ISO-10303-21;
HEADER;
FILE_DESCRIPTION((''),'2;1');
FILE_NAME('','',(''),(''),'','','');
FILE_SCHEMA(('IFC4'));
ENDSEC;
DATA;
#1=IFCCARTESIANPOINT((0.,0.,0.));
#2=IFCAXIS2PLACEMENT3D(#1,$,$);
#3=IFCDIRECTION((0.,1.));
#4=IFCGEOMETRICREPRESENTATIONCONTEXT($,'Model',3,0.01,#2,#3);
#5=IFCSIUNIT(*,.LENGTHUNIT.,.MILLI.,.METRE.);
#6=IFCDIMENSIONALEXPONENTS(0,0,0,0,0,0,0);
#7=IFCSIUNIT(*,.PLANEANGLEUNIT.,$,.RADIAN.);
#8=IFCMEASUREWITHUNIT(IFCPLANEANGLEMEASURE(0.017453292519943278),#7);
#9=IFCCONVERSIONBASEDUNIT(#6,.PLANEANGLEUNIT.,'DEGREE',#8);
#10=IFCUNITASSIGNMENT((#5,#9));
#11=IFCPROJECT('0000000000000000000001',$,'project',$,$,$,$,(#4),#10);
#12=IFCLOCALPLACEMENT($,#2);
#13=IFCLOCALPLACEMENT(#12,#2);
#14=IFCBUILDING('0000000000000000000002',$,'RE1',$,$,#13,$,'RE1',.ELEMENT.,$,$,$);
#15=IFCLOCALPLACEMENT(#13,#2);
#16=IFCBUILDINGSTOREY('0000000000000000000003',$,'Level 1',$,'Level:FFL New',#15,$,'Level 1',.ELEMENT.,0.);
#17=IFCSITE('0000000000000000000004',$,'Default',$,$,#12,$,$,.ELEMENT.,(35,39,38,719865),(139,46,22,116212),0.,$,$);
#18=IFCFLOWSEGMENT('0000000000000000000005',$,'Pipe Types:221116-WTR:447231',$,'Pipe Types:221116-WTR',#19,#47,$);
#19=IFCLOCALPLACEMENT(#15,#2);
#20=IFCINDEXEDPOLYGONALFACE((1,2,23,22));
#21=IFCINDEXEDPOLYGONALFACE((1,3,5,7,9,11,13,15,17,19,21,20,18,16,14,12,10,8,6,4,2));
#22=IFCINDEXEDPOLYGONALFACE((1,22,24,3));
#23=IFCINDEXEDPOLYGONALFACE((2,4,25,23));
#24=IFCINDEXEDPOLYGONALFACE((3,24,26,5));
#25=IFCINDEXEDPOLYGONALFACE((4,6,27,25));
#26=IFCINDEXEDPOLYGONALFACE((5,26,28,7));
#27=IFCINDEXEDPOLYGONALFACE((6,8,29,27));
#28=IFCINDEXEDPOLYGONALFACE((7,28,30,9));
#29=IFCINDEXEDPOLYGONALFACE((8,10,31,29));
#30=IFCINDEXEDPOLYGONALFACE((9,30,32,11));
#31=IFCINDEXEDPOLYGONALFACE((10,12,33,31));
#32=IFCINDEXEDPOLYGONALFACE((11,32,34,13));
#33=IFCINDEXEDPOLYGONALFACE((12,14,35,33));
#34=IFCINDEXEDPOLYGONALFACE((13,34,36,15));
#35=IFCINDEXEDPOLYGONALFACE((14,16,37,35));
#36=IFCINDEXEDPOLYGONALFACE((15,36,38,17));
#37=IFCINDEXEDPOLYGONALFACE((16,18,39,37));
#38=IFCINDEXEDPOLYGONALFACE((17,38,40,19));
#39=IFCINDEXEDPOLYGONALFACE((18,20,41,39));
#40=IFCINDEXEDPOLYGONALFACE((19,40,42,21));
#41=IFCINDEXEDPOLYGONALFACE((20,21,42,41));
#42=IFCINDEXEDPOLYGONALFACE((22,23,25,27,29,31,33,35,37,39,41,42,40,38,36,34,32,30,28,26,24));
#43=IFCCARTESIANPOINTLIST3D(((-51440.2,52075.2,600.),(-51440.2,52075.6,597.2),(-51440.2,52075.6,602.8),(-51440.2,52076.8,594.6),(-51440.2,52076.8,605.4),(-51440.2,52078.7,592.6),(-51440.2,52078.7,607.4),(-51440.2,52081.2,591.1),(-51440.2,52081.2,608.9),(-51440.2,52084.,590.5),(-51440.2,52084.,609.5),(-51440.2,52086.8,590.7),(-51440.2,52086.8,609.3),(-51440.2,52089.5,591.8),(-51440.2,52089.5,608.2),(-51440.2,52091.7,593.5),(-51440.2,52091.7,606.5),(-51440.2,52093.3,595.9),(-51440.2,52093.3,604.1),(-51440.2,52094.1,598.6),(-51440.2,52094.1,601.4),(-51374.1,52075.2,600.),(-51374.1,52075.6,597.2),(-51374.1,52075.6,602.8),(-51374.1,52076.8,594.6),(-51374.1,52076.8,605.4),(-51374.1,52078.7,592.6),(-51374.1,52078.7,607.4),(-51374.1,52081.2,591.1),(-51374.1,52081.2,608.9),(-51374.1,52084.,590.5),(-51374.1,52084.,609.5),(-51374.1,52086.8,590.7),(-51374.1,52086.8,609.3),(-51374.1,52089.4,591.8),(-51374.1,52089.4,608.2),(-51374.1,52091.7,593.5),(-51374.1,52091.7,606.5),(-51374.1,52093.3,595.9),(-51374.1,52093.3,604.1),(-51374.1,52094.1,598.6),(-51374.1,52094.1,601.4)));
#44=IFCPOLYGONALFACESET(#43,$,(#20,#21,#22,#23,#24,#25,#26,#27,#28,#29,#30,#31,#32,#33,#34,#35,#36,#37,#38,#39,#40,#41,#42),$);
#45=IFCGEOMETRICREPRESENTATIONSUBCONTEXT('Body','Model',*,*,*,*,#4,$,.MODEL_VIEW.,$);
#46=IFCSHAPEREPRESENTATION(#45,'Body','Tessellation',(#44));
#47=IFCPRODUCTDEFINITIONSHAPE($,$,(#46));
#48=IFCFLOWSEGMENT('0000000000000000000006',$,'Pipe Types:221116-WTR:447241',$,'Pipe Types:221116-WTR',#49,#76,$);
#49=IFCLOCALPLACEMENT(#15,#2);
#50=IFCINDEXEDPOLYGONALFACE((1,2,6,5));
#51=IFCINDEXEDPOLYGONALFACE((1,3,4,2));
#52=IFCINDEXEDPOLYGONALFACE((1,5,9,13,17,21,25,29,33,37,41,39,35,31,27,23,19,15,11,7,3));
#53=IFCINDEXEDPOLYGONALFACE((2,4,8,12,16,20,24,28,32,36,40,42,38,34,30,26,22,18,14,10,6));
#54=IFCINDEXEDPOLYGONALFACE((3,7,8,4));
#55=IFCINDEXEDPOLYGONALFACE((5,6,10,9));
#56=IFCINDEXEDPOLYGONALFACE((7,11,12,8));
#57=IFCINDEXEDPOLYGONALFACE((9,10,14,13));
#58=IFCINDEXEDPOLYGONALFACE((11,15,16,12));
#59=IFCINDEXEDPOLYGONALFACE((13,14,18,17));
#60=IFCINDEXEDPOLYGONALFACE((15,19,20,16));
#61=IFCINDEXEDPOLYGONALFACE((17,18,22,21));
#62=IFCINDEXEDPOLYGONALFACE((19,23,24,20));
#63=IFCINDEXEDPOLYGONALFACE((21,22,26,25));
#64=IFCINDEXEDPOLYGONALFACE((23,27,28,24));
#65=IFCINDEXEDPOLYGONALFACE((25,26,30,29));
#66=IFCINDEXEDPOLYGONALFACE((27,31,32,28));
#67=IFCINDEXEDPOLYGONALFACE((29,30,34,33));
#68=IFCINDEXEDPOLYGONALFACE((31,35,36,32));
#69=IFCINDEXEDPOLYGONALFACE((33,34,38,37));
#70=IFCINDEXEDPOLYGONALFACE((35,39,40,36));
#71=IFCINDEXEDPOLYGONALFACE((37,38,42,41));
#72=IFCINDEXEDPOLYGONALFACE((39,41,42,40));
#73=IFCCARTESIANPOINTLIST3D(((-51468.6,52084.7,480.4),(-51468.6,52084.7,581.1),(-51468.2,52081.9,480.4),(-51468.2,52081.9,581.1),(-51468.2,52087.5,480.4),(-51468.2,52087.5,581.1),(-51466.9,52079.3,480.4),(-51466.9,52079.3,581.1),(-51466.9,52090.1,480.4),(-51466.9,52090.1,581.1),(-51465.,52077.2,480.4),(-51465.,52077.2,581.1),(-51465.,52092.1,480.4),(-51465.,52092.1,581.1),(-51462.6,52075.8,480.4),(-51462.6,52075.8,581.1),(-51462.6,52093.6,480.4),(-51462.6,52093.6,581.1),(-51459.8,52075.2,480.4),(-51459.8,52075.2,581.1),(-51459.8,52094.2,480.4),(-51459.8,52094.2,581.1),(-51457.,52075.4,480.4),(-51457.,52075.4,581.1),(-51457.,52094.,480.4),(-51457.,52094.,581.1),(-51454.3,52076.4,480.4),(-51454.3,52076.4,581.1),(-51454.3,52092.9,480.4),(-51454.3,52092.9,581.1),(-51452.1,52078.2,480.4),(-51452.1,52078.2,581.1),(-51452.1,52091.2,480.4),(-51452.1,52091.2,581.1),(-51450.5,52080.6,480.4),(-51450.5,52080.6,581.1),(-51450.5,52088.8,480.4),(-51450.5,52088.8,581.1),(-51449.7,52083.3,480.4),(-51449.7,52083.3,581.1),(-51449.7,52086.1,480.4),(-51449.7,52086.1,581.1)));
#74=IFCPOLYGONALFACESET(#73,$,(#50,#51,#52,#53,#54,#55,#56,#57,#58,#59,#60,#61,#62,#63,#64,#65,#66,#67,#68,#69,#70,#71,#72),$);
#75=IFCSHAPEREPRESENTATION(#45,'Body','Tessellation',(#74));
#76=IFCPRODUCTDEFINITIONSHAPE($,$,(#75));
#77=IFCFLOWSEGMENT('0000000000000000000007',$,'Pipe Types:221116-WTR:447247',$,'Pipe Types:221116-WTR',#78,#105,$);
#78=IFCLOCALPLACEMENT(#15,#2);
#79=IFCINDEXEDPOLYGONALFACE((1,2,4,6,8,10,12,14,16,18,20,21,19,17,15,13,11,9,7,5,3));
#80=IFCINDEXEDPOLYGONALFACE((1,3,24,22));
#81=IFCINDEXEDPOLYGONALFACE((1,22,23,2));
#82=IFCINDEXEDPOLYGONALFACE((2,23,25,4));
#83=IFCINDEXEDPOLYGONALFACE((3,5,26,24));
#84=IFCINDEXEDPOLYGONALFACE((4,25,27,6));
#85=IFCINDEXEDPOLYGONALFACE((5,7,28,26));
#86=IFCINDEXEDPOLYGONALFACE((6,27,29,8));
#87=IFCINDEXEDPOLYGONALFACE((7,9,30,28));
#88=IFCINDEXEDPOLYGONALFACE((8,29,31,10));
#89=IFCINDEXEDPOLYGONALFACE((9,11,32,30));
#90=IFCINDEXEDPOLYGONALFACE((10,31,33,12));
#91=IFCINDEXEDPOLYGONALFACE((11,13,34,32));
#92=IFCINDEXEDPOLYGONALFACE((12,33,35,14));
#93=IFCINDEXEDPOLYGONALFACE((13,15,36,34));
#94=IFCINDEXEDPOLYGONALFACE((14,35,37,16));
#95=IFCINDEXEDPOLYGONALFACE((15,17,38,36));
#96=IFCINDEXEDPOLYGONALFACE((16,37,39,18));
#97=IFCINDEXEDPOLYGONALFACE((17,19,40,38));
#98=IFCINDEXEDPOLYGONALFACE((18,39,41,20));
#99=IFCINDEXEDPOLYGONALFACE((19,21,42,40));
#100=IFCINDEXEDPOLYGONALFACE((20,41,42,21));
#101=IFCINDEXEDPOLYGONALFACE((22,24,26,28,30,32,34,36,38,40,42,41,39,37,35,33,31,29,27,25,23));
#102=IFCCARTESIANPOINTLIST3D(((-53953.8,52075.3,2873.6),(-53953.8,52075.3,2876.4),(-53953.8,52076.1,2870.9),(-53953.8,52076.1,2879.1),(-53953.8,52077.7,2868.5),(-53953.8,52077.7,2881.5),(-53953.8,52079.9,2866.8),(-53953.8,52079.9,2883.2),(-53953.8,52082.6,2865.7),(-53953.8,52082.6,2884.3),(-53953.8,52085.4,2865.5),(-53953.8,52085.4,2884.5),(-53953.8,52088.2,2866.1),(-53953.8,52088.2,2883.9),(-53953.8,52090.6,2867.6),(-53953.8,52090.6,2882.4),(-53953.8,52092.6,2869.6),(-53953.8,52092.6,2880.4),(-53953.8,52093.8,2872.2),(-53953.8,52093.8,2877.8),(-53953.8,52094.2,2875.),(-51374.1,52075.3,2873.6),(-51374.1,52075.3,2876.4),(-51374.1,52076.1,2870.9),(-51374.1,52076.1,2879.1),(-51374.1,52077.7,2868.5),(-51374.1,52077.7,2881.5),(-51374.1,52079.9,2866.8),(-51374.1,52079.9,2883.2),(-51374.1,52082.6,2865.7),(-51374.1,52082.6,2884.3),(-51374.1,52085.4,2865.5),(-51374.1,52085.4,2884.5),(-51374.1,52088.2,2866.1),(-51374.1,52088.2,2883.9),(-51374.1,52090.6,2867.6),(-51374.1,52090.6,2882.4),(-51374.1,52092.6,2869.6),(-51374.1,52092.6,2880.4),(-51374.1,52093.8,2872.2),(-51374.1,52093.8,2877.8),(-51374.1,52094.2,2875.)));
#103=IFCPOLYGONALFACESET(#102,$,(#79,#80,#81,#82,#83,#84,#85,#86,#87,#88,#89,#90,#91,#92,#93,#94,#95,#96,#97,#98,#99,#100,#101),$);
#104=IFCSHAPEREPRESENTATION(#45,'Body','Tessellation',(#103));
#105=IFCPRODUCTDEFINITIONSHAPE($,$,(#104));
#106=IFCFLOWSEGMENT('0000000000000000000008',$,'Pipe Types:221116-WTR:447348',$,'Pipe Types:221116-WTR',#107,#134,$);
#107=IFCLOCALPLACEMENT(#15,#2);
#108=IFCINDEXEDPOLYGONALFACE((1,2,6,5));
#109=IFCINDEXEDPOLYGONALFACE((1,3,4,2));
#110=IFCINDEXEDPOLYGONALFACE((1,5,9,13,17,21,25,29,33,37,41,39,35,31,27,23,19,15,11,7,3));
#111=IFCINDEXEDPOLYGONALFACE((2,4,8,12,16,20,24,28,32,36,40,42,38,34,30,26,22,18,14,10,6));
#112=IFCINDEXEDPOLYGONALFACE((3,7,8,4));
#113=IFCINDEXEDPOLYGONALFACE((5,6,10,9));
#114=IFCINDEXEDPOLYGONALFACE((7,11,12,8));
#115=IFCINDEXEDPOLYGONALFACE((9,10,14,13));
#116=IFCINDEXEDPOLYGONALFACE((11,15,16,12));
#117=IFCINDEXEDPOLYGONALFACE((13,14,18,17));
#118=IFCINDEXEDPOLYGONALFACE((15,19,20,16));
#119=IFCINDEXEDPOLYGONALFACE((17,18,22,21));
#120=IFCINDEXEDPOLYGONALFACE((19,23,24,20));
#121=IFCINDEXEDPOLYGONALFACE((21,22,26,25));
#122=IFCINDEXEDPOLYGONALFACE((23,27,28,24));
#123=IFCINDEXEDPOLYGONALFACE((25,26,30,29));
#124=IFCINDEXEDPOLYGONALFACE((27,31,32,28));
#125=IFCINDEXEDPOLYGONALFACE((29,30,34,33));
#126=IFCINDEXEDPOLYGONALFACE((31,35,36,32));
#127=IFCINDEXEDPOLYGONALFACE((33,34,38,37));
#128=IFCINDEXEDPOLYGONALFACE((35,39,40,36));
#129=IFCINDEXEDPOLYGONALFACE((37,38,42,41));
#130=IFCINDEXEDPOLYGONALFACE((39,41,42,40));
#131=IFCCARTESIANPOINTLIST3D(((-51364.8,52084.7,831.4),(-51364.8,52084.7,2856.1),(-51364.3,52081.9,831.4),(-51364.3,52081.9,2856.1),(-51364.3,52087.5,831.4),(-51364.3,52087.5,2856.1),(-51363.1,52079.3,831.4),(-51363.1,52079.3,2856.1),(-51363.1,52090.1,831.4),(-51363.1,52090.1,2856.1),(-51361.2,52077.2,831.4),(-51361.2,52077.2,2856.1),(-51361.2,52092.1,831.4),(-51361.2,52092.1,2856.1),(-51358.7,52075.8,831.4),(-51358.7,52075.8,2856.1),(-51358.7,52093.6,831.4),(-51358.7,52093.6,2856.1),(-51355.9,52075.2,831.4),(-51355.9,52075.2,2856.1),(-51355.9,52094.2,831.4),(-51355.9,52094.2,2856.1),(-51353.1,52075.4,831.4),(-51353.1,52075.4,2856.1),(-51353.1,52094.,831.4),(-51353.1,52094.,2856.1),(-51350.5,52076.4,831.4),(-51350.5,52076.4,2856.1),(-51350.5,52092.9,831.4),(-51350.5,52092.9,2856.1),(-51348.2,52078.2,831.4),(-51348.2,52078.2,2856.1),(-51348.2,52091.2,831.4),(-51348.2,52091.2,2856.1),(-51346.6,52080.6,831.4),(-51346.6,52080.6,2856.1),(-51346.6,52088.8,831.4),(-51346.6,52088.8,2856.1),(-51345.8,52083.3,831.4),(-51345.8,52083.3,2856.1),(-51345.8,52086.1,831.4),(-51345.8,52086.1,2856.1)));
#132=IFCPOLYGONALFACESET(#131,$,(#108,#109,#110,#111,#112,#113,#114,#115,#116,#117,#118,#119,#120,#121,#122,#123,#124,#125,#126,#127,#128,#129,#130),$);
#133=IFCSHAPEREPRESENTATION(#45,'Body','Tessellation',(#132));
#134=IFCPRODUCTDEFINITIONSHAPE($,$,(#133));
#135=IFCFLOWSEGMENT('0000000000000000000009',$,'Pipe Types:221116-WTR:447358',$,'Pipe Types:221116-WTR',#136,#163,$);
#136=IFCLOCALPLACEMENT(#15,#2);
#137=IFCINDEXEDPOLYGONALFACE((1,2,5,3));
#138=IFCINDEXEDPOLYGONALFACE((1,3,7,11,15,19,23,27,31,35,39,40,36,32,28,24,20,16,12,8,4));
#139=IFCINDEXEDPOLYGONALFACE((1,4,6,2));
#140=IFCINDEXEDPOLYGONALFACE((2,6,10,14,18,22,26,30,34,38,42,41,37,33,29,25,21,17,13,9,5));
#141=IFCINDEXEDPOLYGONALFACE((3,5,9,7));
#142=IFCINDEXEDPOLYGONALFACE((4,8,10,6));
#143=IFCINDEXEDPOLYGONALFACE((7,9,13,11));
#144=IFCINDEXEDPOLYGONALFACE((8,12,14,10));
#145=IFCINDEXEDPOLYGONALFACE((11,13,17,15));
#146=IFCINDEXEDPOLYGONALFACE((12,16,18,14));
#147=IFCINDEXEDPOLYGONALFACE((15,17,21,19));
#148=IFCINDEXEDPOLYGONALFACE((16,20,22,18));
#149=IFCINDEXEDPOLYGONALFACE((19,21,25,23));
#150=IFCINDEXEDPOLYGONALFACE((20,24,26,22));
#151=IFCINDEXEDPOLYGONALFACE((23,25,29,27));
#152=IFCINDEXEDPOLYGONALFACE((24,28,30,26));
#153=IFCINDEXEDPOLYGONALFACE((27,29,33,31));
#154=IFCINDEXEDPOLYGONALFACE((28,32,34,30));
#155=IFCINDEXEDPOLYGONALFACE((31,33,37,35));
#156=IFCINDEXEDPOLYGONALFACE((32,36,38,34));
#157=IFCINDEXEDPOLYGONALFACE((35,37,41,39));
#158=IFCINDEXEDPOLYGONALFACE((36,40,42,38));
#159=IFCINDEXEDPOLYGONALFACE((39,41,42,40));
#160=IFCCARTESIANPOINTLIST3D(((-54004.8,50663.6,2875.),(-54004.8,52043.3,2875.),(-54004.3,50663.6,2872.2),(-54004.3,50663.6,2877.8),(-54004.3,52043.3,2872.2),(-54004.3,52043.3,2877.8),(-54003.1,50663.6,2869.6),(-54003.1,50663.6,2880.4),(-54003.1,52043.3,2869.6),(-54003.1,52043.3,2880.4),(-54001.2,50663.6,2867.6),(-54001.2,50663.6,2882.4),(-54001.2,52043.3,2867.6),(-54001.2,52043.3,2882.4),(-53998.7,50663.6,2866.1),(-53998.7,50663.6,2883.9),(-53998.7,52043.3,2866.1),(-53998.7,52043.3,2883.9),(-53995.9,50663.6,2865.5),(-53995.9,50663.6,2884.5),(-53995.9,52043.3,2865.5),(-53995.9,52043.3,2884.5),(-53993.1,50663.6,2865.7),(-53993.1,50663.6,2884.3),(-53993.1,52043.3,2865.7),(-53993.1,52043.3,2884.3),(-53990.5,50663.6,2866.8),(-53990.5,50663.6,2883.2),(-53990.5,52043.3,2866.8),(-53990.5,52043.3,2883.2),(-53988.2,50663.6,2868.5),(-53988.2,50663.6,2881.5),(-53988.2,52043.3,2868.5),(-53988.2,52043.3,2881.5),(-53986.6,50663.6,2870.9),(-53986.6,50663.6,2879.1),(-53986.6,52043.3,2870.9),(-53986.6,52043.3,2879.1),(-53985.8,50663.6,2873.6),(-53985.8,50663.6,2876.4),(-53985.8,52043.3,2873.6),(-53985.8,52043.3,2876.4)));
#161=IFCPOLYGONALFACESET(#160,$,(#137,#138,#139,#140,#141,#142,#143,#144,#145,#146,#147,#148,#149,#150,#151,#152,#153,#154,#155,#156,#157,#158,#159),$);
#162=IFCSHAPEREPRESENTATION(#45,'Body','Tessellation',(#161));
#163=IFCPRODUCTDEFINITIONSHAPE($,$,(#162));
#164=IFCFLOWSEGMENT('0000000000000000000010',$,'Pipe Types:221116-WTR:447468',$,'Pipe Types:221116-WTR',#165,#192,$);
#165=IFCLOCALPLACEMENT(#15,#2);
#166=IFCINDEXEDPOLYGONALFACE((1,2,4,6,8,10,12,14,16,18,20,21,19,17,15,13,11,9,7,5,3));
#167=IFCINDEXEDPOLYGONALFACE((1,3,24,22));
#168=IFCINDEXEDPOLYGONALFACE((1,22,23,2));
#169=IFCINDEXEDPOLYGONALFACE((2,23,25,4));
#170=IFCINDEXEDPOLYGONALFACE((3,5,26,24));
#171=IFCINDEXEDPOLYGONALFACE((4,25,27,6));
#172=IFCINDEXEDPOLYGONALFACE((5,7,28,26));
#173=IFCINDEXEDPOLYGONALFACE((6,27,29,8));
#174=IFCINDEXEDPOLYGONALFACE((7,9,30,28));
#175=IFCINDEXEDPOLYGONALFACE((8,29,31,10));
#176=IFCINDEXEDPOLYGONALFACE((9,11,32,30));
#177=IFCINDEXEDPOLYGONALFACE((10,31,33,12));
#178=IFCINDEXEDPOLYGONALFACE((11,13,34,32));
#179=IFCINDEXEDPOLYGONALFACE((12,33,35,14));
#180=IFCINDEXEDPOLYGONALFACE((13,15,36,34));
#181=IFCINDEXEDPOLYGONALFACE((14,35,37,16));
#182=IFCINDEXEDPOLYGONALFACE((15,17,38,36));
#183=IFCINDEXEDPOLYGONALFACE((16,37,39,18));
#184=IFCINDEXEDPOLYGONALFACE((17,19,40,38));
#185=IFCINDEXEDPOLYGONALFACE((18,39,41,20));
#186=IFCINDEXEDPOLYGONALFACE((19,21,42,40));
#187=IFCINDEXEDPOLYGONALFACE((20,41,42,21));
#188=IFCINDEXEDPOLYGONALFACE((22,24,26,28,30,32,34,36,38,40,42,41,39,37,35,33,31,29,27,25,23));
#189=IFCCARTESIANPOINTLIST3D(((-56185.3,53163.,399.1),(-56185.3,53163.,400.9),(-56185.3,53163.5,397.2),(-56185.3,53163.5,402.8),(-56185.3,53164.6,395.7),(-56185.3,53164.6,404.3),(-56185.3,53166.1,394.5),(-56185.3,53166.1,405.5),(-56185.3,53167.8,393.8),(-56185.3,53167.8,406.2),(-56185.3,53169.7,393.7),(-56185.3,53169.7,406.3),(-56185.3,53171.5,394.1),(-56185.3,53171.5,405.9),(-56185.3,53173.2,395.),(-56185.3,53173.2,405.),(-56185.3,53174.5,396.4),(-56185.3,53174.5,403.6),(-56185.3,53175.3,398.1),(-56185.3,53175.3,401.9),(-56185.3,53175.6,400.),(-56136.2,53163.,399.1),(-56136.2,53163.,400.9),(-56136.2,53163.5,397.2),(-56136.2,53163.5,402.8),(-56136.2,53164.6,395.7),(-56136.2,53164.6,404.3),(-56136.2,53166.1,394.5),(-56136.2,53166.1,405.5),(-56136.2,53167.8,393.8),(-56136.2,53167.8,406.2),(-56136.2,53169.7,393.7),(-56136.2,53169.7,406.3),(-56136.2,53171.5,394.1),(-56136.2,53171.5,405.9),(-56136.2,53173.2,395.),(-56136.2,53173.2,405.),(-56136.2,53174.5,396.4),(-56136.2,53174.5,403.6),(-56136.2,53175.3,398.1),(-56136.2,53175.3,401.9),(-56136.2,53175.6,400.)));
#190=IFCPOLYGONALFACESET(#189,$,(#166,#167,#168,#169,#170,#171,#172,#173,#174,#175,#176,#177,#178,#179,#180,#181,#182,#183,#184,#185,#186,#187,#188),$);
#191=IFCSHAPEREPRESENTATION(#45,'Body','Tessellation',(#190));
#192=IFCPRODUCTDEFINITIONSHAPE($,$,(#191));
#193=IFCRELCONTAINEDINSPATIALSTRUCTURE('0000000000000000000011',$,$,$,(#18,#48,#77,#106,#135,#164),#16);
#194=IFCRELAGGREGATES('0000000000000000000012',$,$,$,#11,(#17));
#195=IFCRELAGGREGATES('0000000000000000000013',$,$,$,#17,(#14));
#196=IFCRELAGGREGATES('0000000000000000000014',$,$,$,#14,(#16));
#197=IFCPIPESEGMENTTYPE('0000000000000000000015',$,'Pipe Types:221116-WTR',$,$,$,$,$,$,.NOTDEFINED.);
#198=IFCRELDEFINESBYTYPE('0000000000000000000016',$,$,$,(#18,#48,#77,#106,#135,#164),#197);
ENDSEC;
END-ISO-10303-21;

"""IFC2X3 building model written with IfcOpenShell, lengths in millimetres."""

from ifc_helpers import new_model, entity, si_unit, converted_unit, direction, frame, frame_2d, origin, origin_2d_with_axis, place, context, subcontext, project, spatial, circle, extrude, type_object, element, save


model = new_model("IFC2X3")

# Units and contexts
model_context = context("Model", 3, precision=0.01, world=origin(), true_north=direction((0.0, 1.0)))
body_context = subcontext(model_context, "Body", "Model", "MODEL_VIEW")
ifc_project = project(units=[si_unit("LENGTHUNIT", "METRE", prefix="MILLI"), converted_unit("PLANEANGLEUNIT", "DEGREE", entity("IfcPlaneAngleMeasure", 0.017453292519943278), si_unit("PLANEANGLEUNIT", "RADIAN"), dimensions=[0, 0, 0, 0, 0, 0, 0])], contexts=[model_context])

# Site, building, storey
site_placement = place(None, origin())
site = spatial("IfcSite", under=ifc_project, at=site_placement, Name="Default", CompositionType="ELEMENT", RefLatitude=(35, 39, 38, 719865), RefLongitude=(139, 46, 22, 116212), RefElevation=0.0)
building_placement = place(site_placement, origin())
building = spatial("IfcBuilding", under=site, at=building_placement, Name="RE1", LongName="RE1", CompositionType="ELEMENT")
storey_placement = place(building_placement, origin())
storey = spatial("IfcBuildingStorey", under=building, at=storey_placement, Name="Level 1", ObjectType="Level:FFL New", LongName="Level 1", CompositionType="ELEMENT", Elevation=0.0)

# Flow segments
pipe_segment_type_1 = type_object("IfcPipeSegmentType", Name="Pipe Types:221116-WTR", PredefinedType="NOTDEFINED")
flow_segment_1_placement = place(storey_placement, origin())
element("IfcFlowSegment", 1, at=flow_segment_1_placement, inside=storey, type_object=pipe_segment_type_1, Name="Pipe Types:221116-WTR:447231", ObjectType="Pipe Types:221116-WTR", context=body_context, shape_type="SweptSolid", body=[
    extrude(circle(Radius=9.5, at=origin_2d_with_axis()), frame((-51440.2, 52084.7, 600.0), z_axis=(1.0, -0.000013, 0.0), x_axis=(-0.000013, -1.0, 0.0)), (0.0, 0.0, 1.0), 66.0),
])
flow_segment_2_placement = place(storey_placement, origin())
element("IfcFlowSegment", 2, at=flow_segment_2_placement, inside=storey, type_object=pipe_segment_type_1, Name="Pipe Types:221116-WTR:447241", ObjectType="Pipe Types:221116-WTR", context=body_context, shape_type="SweptSolid", body=[
    extrude(circle(Radius=9.5, at=origin_2d_with_axis()), frame((-51459.1, 52084.7, 480.4), z_axis=(0.0, 0.0, 1.0), x_axis=(-1.0, 0.0, 0.0)), (0.0, 0.0, 1.0), 100.7),
])
flow_segment_3_placement = place(storey_placement, origin())
element("IfcFlowSegment", 3, at=flow_segment_3_placement, inside=storey, type_object=pipe_segment_type_1, Name="Pipe Types:221116-WTR:447247", ObjectType="Pipe Types:221116-WTR", context=body_context, shape_type="SweptSolid", body=[
    extrude(circle(Radius=9.5, at=frame_2d((0.0, 0.0), x_axis=(1.0, 0.0))), frame((-53953.8, 52084.7, 2875.0), z_axis=(1.0, 0.0, 0.0), x_axis=(0.0, 1.0, 0.0)), (0.0, 0.0, 1.0), 2579.7),
])
flow_segment_4_placement = place(storey_placement, origin())
element("IfcFlowSegment", 4, at=flow_segment_4_placement, inside=storey, type_object=pipe_segment_type_1, Name="Pipe Types:221116-WTR:447348", ObjectType="Pipe Types:221116-WTR", context=body_context, shape_type="SweptSolid", body=[
    extrude(circle(Radius=9.5, at=origin_2d_with_axis()), frame((-51355.2, 52084.7, 831.4), z_axis=(0.0, 0.0, 1.0), x_axis=(-1.0, 0.0, 0.0)), (0.0, 0.0, 1.0), 2024.7),
])
flow_segment_5_placement = place(storey_placement, origin())
element("IfcFlowSegment", 5, at=flow_segment_5_placement, inside=storey, type_object=pipe_segment_type_1, Name="Pipe Types:221116-WTR:447358", ObjectType="Pipe Types:221116-WTR", context=body_context, shape_type="SweptSolid", body=[
    extrude(circle(Radius=9.5, at=frame_2d((0.0, 0.0), x_axis=(1.0, 0.0))), frame((-53995.2, 50663.6, 2875.0), z_axis=(0.0, 1.0, 0.0), x_axis=(-1.0, 0.0, 0.0)), (0.0, 0.0, 1.0), 1379.7),
])
flow_segment_6_placement = place(storey_placement, origin())
element("IfcFlowSegment", 6, at=flow_segment_6_placement, inside=storey, type_object=pipe_segment_type_1, Name="Pipe Types:221116-WTR:447468", ObjectType="Pipe Types:221116-WTR", context=body_context, shape_type="SweptSolid", body=[
    extrude(circle(Radius=6.3, at=frame_2d((0.0, 0.0), x_axis=(1.0, 0.0))), frame((-56185.3, 53169.2, 400.0), z_axis=(1.0, 0.0, 0.0), x_axis=(0.0, 1.0, 0.0)), (0.0, 0.0, 1.0), 49.1),
])

save(model, "model.ifc")
